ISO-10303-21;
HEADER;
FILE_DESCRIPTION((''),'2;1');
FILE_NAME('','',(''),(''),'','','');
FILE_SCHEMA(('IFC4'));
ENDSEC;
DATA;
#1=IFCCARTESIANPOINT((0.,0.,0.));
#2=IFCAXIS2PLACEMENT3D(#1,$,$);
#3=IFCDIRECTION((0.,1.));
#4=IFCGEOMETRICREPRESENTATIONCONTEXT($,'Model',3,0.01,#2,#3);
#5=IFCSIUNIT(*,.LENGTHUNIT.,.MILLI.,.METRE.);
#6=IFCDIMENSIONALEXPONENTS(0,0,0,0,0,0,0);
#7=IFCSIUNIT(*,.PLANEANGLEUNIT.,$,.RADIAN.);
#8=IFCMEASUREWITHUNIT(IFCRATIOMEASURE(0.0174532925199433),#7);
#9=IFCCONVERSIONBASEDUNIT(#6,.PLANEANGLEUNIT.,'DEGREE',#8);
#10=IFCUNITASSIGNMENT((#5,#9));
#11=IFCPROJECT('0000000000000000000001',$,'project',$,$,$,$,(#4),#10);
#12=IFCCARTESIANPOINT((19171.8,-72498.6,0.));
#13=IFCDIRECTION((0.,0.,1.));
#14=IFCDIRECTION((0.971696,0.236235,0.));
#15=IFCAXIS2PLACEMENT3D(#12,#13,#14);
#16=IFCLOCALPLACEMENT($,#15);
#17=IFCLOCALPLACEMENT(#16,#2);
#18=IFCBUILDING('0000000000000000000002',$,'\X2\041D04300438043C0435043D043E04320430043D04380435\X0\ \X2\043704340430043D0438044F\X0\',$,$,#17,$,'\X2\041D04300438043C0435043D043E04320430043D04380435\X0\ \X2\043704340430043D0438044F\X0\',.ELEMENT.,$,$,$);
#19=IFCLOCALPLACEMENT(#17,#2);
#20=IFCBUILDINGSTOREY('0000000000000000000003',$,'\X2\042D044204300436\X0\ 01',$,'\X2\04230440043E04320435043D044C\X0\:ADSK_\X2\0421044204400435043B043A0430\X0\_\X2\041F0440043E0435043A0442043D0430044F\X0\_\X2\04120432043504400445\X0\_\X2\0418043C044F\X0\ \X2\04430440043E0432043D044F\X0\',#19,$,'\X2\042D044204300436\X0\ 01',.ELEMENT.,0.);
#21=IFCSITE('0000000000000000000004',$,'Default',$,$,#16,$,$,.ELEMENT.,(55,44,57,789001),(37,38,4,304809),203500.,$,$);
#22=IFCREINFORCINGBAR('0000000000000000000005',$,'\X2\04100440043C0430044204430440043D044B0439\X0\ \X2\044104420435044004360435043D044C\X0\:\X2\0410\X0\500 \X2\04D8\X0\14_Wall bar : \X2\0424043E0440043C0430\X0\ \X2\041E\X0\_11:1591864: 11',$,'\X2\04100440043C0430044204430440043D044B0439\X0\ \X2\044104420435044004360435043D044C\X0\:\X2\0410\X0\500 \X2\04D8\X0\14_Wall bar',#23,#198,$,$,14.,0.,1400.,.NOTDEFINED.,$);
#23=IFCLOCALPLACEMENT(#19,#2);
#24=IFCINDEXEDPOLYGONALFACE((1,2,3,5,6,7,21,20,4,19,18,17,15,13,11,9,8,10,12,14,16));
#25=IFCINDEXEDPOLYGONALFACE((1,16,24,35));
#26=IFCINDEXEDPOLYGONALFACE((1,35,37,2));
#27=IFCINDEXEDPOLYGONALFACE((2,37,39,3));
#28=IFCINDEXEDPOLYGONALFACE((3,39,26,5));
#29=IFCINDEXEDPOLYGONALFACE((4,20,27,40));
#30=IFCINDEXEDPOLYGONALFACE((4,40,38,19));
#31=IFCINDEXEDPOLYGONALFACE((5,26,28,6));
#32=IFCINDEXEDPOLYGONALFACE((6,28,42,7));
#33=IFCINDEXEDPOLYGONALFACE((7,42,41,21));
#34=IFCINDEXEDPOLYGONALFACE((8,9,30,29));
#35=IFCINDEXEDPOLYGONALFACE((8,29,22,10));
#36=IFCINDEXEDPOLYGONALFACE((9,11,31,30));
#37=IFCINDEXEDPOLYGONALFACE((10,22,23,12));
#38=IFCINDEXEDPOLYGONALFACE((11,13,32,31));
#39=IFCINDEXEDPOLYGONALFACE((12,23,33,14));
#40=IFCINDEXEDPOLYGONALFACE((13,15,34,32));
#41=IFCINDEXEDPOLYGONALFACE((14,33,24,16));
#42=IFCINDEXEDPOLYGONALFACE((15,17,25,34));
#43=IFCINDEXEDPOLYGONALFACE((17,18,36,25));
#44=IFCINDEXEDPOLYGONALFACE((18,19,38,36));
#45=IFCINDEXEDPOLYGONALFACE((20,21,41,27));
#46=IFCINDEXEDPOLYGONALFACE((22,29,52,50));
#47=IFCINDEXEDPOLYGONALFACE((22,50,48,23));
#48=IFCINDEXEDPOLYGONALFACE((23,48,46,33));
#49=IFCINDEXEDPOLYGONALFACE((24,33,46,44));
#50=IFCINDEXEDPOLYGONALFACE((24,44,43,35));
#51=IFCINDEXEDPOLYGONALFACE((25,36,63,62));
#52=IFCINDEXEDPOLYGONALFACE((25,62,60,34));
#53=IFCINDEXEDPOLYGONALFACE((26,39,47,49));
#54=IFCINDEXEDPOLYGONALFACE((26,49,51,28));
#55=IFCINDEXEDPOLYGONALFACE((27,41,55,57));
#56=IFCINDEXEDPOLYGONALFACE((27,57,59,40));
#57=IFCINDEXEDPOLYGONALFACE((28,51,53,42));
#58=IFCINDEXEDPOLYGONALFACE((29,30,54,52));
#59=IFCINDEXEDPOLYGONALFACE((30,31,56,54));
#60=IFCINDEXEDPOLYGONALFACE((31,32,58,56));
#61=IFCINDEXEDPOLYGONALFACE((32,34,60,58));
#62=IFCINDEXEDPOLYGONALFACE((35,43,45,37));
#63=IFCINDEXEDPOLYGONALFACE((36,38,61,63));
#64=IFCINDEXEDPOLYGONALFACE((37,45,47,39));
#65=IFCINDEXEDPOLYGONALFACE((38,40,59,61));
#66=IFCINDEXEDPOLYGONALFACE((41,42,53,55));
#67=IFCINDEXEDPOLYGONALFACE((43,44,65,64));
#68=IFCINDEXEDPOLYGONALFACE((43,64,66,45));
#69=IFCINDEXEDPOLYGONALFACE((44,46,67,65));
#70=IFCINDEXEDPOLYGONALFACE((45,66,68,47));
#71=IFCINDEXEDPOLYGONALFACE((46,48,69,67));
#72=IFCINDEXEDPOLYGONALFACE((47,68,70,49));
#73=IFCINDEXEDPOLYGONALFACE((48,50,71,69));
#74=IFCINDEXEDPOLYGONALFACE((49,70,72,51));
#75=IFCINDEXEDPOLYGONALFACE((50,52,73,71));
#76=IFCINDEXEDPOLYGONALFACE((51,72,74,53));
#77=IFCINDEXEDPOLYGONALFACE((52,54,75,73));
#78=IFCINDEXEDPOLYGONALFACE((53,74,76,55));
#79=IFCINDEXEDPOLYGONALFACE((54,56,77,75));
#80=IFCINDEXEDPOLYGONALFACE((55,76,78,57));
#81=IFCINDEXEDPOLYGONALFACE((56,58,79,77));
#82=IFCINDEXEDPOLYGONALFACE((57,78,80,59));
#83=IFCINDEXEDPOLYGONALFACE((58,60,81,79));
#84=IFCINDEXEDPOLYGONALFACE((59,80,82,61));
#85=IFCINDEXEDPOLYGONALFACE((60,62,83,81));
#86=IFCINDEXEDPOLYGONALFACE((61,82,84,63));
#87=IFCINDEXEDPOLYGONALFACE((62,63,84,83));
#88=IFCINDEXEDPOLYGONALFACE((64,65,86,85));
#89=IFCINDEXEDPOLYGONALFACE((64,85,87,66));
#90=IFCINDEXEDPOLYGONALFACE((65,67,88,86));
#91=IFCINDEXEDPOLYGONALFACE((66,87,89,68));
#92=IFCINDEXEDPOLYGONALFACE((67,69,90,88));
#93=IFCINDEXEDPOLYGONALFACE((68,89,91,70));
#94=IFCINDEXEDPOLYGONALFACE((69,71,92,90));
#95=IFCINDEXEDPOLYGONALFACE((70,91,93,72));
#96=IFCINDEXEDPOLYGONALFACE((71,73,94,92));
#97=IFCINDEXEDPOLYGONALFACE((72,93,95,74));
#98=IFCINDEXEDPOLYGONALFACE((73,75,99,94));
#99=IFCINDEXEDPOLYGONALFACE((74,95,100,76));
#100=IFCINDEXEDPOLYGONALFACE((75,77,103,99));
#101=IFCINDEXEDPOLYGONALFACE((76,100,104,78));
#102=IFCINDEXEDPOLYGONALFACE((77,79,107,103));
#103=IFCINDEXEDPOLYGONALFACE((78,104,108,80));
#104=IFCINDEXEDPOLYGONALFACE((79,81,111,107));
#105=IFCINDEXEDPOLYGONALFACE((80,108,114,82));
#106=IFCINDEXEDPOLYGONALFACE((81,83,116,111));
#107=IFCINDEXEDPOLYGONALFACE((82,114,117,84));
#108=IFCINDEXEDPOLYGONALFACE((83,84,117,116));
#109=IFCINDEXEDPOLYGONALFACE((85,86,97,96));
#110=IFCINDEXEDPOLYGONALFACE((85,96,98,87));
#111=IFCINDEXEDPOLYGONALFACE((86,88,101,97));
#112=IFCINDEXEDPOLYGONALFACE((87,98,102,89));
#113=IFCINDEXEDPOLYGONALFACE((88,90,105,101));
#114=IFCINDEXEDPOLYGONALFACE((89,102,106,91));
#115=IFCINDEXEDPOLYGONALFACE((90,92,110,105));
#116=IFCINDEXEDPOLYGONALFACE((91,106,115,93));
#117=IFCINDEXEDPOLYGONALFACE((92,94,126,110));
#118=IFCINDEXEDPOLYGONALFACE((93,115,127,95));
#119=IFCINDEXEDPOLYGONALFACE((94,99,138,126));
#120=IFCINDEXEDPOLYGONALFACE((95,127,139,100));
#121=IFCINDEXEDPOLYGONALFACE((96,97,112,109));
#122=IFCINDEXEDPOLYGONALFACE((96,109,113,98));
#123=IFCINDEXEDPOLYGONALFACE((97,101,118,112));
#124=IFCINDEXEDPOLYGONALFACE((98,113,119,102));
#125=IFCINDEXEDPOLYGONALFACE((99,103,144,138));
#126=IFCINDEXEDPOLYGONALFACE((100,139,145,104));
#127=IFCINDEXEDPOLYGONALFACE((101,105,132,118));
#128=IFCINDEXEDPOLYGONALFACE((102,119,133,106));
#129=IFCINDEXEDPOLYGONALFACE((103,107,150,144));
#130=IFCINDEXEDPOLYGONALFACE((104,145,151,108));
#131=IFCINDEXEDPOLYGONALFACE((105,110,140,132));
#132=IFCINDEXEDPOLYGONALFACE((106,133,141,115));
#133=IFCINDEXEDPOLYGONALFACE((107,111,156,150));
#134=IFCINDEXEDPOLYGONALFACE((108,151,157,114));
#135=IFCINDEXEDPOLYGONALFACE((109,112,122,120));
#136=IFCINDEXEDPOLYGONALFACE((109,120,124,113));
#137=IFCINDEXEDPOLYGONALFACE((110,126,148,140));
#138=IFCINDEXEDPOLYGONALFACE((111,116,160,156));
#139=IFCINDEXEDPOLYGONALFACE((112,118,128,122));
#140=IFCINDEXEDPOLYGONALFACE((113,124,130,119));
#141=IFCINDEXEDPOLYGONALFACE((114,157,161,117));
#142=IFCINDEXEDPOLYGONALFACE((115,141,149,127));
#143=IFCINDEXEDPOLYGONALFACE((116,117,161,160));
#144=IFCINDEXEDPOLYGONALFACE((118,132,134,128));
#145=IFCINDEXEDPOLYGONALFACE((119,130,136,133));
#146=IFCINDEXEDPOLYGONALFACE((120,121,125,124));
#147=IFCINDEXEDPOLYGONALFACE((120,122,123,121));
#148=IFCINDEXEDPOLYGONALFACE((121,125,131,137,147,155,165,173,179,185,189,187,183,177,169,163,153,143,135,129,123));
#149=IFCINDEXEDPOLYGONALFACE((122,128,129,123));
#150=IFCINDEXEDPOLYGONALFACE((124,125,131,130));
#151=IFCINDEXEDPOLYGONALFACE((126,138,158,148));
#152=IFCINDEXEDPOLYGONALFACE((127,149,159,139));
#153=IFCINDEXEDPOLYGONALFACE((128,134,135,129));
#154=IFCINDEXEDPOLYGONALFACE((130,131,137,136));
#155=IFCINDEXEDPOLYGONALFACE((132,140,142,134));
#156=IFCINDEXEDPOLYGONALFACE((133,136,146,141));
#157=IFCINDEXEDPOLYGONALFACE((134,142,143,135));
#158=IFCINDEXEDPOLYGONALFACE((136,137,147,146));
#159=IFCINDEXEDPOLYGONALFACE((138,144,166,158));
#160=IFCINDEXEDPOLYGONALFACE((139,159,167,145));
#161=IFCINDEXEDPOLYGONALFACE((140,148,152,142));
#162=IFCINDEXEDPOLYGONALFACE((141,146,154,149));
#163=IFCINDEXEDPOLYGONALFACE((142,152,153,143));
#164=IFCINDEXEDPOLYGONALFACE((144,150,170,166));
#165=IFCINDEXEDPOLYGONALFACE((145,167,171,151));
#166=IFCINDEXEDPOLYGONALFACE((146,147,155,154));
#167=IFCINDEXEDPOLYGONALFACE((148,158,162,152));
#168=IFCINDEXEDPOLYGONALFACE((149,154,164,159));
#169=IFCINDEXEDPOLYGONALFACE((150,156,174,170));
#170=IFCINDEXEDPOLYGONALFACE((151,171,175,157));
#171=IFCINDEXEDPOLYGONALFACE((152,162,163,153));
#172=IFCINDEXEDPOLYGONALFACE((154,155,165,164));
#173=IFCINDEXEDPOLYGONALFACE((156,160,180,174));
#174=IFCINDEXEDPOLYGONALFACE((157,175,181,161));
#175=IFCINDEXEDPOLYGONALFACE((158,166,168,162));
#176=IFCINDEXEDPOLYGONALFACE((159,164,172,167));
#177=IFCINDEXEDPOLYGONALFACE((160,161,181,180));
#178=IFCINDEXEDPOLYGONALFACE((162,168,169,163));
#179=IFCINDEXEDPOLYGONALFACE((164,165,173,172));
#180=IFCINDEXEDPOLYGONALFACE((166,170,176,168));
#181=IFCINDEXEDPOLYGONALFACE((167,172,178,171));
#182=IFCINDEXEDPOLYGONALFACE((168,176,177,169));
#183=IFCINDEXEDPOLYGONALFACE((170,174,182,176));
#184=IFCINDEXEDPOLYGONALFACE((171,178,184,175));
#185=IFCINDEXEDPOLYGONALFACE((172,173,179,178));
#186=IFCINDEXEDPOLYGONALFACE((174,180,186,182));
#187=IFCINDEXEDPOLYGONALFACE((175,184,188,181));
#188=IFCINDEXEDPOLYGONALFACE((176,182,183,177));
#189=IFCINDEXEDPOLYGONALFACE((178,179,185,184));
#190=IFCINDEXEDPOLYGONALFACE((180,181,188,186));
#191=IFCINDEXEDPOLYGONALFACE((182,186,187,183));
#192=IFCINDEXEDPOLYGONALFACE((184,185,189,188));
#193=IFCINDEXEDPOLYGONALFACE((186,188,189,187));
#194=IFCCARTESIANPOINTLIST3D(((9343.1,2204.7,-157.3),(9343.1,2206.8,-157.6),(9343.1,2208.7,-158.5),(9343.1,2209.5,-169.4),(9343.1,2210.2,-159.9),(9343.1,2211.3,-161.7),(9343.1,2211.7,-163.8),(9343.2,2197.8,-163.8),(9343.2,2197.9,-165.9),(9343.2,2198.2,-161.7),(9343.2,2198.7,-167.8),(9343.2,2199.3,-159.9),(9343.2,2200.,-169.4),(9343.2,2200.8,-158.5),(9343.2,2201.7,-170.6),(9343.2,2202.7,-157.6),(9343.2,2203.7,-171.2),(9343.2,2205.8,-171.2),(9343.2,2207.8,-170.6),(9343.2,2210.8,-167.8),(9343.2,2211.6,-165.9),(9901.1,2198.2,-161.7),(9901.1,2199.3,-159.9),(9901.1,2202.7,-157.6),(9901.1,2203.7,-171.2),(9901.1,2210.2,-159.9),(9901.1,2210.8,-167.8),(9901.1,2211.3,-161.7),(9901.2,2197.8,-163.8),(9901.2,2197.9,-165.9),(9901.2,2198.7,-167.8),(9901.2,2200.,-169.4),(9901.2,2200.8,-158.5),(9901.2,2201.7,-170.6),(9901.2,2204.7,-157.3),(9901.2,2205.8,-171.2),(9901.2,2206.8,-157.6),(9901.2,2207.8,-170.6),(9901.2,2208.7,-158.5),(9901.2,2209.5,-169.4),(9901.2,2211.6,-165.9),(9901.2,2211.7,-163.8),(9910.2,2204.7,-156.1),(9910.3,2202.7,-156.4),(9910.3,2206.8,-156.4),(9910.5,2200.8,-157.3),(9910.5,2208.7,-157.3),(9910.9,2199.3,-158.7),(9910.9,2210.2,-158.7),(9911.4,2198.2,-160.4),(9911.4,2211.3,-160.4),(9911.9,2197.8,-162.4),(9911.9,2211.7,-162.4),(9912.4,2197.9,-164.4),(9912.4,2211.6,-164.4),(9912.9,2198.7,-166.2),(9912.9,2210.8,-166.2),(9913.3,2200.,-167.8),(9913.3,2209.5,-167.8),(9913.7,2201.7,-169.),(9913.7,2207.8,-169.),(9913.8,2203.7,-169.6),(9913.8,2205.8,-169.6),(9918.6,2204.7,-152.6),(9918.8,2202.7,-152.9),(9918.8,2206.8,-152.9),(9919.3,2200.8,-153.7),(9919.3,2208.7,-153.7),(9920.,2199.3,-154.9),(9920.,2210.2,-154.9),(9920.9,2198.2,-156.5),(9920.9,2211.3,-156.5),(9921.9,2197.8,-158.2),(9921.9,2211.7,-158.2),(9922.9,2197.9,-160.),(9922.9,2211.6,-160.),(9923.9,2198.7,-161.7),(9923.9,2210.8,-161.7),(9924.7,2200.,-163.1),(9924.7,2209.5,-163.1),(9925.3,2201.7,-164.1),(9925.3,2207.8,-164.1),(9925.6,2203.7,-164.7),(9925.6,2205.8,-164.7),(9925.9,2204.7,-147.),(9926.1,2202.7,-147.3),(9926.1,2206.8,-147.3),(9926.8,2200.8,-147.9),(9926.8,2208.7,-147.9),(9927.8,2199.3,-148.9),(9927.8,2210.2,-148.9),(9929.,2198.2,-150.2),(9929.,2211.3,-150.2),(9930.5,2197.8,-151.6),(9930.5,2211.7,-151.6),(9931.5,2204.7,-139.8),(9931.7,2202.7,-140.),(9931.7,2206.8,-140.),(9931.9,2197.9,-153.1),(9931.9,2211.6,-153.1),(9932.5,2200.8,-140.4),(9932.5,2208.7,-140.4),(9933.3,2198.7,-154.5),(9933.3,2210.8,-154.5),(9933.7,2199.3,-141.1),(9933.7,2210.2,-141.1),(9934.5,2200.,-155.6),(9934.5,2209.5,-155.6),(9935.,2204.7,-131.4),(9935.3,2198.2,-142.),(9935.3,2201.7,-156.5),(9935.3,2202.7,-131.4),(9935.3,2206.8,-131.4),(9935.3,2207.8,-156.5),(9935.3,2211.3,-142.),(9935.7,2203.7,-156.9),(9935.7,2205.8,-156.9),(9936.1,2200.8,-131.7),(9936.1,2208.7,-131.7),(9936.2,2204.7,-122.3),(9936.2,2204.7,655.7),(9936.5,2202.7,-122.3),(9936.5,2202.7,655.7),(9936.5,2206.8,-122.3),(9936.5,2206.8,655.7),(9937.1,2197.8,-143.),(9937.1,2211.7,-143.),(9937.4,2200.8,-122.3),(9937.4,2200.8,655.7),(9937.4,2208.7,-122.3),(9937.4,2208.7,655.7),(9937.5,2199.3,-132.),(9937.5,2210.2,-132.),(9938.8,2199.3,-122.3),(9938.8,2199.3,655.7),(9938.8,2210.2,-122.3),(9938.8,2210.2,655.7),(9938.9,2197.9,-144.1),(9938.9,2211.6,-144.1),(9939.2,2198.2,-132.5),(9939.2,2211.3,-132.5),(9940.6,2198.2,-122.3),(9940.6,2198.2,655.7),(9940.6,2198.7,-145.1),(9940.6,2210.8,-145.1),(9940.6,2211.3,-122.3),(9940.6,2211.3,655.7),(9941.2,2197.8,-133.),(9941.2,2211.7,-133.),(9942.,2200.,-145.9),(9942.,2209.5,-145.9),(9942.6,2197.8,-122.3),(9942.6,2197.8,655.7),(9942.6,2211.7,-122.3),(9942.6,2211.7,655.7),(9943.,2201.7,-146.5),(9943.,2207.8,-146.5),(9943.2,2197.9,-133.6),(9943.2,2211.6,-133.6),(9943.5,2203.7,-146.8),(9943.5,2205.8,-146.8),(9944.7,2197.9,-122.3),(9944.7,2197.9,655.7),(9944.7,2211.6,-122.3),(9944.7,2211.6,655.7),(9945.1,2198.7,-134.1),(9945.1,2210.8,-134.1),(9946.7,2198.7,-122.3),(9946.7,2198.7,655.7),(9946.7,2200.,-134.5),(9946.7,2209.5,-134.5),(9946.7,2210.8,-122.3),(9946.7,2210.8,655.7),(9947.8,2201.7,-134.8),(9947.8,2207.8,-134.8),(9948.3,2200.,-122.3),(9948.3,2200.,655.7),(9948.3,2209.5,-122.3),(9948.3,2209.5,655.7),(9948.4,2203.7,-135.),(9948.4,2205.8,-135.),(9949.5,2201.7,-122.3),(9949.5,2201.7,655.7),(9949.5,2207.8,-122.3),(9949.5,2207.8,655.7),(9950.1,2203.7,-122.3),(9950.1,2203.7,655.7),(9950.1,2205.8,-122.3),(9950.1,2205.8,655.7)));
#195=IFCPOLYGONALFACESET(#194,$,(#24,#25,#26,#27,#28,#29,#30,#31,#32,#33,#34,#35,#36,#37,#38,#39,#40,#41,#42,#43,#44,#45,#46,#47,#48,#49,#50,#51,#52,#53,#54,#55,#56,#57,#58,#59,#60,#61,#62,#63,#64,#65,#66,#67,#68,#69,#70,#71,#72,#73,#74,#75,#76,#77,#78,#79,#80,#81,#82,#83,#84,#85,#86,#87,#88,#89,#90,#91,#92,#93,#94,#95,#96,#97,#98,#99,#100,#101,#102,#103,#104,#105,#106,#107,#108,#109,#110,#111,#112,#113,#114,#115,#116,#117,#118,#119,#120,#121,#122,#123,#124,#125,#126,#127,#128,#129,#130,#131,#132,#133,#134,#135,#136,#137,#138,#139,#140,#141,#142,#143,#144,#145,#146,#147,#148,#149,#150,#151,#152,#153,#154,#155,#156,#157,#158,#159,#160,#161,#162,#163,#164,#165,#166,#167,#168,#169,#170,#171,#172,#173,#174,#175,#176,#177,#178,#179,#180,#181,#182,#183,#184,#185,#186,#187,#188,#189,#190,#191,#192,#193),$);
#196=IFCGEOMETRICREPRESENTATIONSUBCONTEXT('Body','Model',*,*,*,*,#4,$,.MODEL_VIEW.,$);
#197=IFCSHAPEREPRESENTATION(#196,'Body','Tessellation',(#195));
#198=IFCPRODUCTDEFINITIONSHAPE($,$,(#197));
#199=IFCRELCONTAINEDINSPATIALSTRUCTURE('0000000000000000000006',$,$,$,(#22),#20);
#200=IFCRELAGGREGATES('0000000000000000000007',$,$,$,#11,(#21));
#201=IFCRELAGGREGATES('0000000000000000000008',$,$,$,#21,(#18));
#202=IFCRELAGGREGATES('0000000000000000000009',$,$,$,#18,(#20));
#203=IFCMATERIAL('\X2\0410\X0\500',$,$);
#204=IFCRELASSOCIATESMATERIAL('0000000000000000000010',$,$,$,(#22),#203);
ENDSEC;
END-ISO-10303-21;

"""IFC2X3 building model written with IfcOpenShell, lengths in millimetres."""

from ifc_helpers import new_model, entity, si_unit, converted_unit, direction, frame, origin, place, context, subcontext, project, spatial, material, element, save


model = new_model("IFC2X3")

# Units and contexts
model_context = context("Model", 3, precision=0.01, world=origin(), true_north=direction((0.0, 1.0)))
body_context = subcontext(model_context, "Body", "Model", "MODEL_VIEW")
ifc_project = project(units=[si_unit("LENGTHUNIT", "METRE", prefix="MILLI"), converted_unit("PLANEANGLEUNIT", "DEGREE", entity("IfcRatioMeasure", 0.0174532925199433), si_unit("PLANEANGLEUNIT", "RADIAN"), dimensions=[0, 0, 0, 0, 0, 0, 0])], contexts=[model_context])

# Site, building, storey
site_placement = place(None, frame((19171.8, -72498.6, 0.0), z_axis=(0.0, 0.0, 1.0), x_axis=(0.971696, 0.236235, 0.0)))
site = spatial("IfcSite", under=ifc_project, at=site_placement, Name="Default", CompositionType="ELEMENT", RefLatitude=(55, 44, 57, 789001), RefLongitude=(37, 38, 4, 304809), RefElevation=203500.0)
building_placement = place(site_placement, origin())
building = spatial("IfcBuilding", under=site, at=building_placement, Name="Наименование здания", LongName="Наименование здания", CompositionType="ELEMENT")
storey_placement = place(building_placement, origin())
storey = spatial("IfcBuildingStorey", under=building, at=storey_placement, Name="Этаж 01", ObjectType="Уровень:ADSK_Стрелка_Проектная_Вверх_Имя уровня", LongName="Этаж 01", CompositionType="ELEMENT", Elevation=0.0)

# Reinforcing bar
ifc_material = material(Name="А500")
placement = place(storey_placement, origin())
element("IfcReinforcingBar", 1, at=placement, inside=storey, material=ifc_material, Name="Арматурный стержень:А500 Ә14_Wall bar : Форма О_11:1591864: 11", ObjectType="Арматурный стержень:А500 Ә14_Wall bar", BarLength=1400.0, BarRole="NOTDEFINED", CrossSectionArea=0.0, NominalDiameter=14.0, context=body_context, shape_type="AdvancedSweptSolid", body=[
    entity("IfcSweptDiskSolid", entity("IfcCompositeCurve", [entity("IfcCompositeCurveSegment", "CONTINUOUS", True, entity("IfcPolyline", [entity("IfcCartesianPoint", [9943.1, 2204.7, 655.7]), entity("IfcCartesianPoint", [9943.1, 2204.7, -122.3])])), entity("IfcCompositeCurveSegment", "CONTINUOUS", True, entity("IfcTrimmedCurve", entity("IfcCircle", entity("IfcAxis2Placement3D", entity("IfcCartesianPoint", [9901.1, 2204.7, -122.3]), entity("IfcDirection", [0.0, 1.0, 0.0]), entity("IfcDirection", [0.0, 0.0, -1.0])), 42.0), [entity("IfcParameterValue", 270.0)], [entity("IfcParameterValue", 360.0)], True, "PARAMETER")), entity("IfcCompositeCurveSegment", "CONTINUOUS", True, entity("IfcPolyline", [entity("IfcCartesianPoint", [9901.1, 2204.7, -164.3]), entity("IfcCartesianPoint", [9343.1, 2204.7, -164.3])]))], False), 7.0, None, 0.0, 92.0),
])

save(model, "model.ifc")
